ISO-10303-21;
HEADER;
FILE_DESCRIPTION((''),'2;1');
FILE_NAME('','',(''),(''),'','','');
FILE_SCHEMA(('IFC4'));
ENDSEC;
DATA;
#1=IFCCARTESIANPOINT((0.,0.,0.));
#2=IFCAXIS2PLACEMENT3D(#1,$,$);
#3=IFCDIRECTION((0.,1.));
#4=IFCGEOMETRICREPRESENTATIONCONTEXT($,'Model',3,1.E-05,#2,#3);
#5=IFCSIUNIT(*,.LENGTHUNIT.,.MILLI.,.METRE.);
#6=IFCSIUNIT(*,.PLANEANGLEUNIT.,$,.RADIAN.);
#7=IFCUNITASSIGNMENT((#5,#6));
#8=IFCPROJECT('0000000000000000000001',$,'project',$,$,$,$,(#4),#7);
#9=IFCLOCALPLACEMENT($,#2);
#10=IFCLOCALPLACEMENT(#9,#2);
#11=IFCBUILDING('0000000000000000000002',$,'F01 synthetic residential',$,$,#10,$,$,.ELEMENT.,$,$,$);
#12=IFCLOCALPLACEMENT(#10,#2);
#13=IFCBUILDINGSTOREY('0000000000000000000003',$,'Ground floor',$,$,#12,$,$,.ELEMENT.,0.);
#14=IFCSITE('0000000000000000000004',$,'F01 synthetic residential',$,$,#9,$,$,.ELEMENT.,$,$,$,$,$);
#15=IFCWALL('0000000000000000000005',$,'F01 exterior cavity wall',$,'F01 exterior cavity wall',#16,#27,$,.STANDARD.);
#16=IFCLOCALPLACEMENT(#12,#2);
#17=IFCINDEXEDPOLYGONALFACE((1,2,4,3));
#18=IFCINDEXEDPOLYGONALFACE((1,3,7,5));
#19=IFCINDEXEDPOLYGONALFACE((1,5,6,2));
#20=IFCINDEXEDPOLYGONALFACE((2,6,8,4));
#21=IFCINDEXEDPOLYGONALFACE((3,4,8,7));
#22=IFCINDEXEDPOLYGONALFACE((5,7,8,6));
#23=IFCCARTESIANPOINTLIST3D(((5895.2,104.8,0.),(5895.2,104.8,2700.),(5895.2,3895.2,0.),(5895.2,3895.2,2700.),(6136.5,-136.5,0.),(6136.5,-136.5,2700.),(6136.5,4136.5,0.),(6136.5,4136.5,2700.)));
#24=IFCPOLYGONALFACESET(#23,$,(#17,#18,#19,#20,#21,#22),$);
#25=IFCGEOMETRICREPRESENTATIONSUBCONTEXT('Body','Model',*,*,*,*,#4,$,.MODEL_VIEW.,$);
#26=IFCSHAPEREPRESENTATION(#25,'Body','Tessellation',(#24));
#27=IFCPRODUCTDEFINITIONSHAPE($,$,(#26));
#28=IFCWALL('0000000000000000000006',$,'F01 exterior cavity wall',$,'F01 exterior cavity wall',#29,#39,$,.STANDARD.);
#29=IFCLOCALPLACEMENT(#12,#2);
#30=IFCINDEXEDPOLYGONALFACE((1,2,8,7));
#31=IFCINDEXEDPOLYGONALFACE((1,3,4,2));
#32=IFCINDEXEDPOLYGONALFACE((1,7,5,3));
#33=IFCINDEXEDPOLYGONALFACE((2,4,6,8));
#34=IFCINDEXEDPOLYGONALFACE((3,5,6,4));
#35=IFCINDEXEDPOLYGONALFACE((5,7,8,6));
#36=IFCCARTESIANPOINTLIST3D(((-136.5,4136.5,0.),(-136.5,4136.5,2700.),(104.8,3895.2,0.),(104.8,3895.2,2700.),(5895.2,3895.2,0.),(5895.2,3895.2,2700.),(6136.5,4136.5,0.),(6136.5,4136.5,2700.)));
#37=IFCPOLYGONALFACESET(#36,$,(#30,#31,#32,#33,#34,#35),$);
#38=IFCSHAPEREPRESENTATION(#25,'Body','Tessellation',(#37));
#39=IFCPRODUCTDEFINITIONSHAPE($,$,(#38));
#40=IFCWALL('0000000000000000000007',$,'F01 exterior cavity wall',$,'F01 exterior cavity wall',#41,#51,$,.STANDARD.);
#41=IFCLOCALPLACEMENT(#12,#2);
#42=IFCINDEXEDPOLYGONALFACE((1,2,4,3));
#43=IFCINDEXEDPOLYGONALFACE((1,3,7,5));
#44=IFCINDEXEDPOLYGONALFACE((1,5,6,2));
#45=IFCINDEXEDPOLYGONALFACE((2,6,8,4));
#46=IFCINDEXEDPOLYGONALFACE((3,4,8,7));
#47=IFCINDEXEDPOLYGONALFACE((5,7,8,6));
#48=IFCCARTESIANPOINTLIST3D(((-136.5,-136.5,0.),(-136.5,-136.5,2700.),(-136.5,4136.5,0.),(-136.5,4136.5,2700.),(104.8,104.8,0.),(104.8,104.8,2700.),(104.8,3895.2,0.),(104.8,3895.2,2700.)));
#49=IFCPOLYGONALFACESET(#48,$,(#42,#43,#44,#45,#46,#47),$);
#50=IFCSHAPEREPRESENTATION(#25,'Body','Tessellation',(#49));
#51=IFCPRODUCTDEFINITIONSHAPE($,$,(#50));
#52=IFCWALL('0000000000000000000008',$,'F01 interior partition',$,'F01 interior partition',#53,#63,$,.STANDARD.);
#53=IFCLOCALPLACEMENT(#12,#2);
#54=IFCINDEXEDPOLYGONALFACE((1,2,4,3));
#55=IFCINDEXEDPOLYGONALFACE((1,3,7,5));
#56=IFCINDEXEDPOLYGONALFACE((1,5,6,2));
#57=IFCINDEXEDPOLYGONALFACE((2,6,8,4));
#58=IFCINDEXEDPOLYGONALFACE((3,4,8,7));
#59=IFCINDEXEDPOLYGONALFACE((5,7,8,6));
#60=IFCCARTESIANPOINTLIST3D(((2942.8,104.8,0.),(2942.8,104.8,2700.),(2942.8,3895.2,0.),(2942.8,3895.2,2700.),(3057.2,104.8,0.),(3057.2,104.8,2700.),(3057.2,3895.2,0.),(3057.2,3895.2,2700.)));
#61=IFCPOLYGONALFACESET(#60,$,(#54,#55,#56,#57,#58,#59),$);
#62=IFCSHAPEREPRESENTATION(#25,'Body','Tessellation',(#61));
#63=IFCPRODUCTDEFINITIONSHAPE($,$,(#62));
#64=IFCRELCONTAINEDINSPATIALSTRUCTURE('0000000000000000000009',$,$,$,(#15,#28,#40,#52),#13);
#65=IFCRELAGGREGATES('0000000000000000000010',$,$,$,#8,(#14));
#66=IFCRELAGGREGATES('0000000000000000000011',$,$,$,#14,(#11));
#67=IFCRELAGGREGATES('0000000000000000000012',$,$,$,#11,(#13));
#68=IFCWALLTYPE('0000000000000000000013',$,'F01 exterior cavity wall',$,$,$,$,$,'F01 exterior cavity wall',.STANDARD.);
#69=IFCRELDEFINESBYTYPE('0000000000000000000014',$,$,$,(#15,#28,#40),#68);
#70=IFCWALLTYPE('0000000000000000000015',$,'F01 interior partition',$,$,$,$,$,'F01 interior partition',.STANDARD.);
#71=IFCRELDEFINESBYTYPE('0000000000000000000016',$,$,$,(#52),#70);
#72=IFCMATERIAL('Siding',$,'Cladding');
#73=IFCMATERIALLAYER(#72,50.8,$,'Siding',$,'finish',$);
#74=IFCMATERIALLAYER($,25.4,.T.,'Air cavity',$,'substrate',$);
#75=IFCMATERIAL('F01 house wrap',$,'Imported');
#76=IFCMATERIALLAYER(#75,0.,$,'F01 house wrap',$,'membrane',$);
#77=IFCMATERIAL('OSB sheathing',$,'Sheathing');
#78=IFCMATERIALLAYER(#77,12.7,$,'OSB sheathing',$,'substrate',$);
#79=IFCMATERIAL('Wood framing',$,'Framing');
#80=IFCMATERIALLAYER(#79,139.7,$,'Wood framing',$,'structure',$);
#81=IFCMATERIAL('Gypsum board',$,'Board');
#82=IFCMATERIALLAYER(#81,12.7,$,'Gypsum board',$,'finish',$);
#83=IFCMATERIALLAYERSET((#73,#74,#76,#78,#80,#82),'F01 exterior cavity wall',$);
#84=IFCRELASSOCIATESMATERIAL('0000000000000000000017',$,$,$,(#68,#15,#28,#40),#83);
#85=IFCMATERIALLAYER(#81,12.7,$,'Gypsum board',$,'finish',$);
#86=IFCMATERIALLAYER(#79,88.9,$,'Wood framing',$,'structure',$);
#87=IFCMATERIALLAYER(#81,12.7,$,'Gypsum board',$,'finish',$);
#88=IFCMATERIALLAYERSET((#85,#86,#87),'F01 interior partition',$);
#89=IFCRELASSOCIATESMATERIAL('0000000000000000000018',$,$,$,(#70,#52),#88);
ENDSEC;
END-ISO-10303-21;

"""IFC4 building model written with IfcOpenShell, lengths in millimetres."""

from ifc_helpers import new_model, si_unit, direction, frame, origin, place, context, subcontext, project, spatial, polyline, outline, extrude, material, layer, layer_set, layer_usage, type_object, element, save


model = new_model("IFC4")

# Units and contexts
model_context = context("Model", 3, precision=1e-05, world=origin(), true_north=direction((0.0, 1.0)))
body_context = subcontext(model_context, "Body", "Model", "MODEL_VIEW")
ifc_project = project(units=[si_unit("LENGTHUNIT", "METRE", prefix="MILLI"), si_unit("PLANEANGLEUNIT", "RADIAN")], contexts=[model_context])

# Site, building, storey
site_placement = place(None, origin())
site = spatial("IfcSite", under=ifc_project, at=site_placement, Name="F01 synthetic residential", CompositionType="ELEMENT")
building_placement = place(site_placement, origin())
building = spatial("IfcBuilding", under=site, at=building_placement, Name="F01 synthetic residential", CompositionType="ELEMENT")
storey_placement = place(building_placement, origin())
storey = spatial("IfcBuildingStorey", under=building, at=storey_placement, Name="Ground floor", CompositionType="ELEMENT", Elevation=0.0)

# Shared definitions
ifc_material_1 = material(Name="Siding", Category="Cladding")
ifc_layer_1 = layer(ifc_material_1, 50.8, Name="Siding", Category="finish")
ifc_layer_2 = layer(None, 25.4, ventilated=True, Name="Air cavity", Category="substrate")
ifc_material_2 = material(Name="F01 house wrap", Category="Imported")
ifc_layer_3 = layer(ifc_material_2, 0.0, Name="F01 house wrap", Category="membrane")
ifc_material_3 = material(Name="OSB sheathing", Category="Sheathing")
ifc_layer_4 = layer(ifc_material_3, 12.7, Name="OSB sheathing", Category="substrate")
ifc_material_4 = material(Name="Wood framing", Category="Framing")
ifc_layer_5 = layer(ifc_material_4, 139.7, Name="Wood framing", Category="structure")
ifc_material_5 = material(Name="Gypsum board", Category="Board")
ifc_layer_6 = layer(ifc_material_5, 12.7, Name="Gypsum board", Category="finish")
ifc_layer_set_1 = layer_set([ifc_layer_1, ifc_layer_2, ifc_layer_3, ifc_layer_4, ifc_layer_5, ifc_layer_6], Name="F01 exterior cavity wall")
wall_type_1 = type_object("IfcWallType", Name="F01 exterior cavity wall", ElementType="F01 exterior cavity wall", PredefinedType="STANDARD", material=ifc_layer_set_1)

# Walls
ifc_layer_usage_1 = layer_usage(ifc_layer_set_1, "AXIS2", "POSITIVE", -120.7)
wall_1_placement = place(storey_placement, frame((6015.9, -15.9, 0.0), z_axis=(0.0, 0.0, 1.0), x_axis=(0.0, 1.0, 0.0)))
element("IfcWall", 1, at=wall_1_placement, inside=storey, type_object=wall_type_1, material=ifc_layer_usage_1, Name="F01 exterior cavity wall", ObjectType="F01 exterior cavity wall", PredefinedType="STANDARD", context=body_context, shape_type="SweptSolid", body=[
    extrude(outline(polyline([(-120.7, -120.7), (4152.4, -120.7), (3911.1, 120.7), (120.7, 120.7), (-120.7, -120.7)])), origin(), (0.0, 0.0, 1.0), 2700.0),
])
ifc_layer_usage_2 = layer_usage(ifc_layer_set_1, "AXIS2", "POSITIVE", -120.7)
wall_2_placement = place(storey_placement, frame((6015.9, 4015.9, 0.0), z_axis=(0.0, 0.0, 1.0), x_axis=(-1.0, 0.0, 0.0)))
element("IfcWall", 2, at=wall_2_placement, inside=storey, type_object=wall_type_1, material=ifc_layer_usage_2, Name="F01 exterior cavity wall", ObjectType="F01 exterior cavity wall", PredefinedType="STANDARD", context=body_context, shape_type="SweptSolid", body=[
    extrude(outline(polyline([(-120.7, -120.7), (6152.4, -120.7), (5911.1, 120.7), (120.7, 120.7), (-120.7, -120.7)])), origin(), (0.0, 0.0, 1.0), 2700.0),
])
ifc_layer_usage_3 = layer_usage(ifc_layer_set_1, "AXIS2", "POSITIVE", -120.7)
wall_3_placement = place(storey_placement, frame((-15.9, 4015.9, 0.0), z_axis=(0.0, 0.0, 1.0), x_axis=(0.0, -1.0, 0.0)))
element("IfcWall", 3, at=wall_3_placement, inside=storey, type_object=wall_type_1, material=ifc_layer_usage_3, Name="F01 exterior cavity wall", ObjectType="F01 exterior cavity wall", PredefinedType="STANDARD", context=body_context, shape_type="SweptSolid", body=[
    extrude(outline(polyline([(-120.7, -120.7), (4152.4, -120.7), (3911.1, 120.7), (120.7, 120.7), (-120.7, -120.7)])), origin(), (0.0, 0.0, 1.0), 2700.0),
])
ifc_layer_7 = layer(ifc_material_5, 12.7, Name="Gypsum board", Category="finish")
ifc_layer_8 = layer(ifc_material_4, 88.9, Name="Wood framing", Category="structure")
ifc_layer_9 = layer(ifc_material_5, 12.7, Name="Gypsum board", Category="finish")
ifc_layer_set_2 = layer_set([ifc_layer_7, ifc_layer_8, ifc_layer_9], Name="F01 interior partition")
ifc_layer_usage_4 = layer_usage(ifc_layer_set_2, "AXIS2", "NEGATIVE", 57.1)
wall_type_2 = type_object("IfcWallType", Name="F01 interior partition", ElementType="F01 interior partition", PredefinedType="STANDARD", material=ifc_layer_set_2)
wall_4_placement = place(storey_placement, frame((3000.0, 0.0, 0.0), z_axis=(0.0, 0.0, 1.0), x_axis=(0.0, 1.0, 0.0)))
element("IfcWall", 4, at=wall_4_placement, inside=storey, type_object=wall_type_2, material=ifc_layer_usage_4, Name="F01 interior partition", ObjectType="F01 interior partition", PredefinedType="STANDARD", context=body_context, shape_type="SweptSolid", body=[
    extrude(outline(polyline([(104.8, -57.1), (3895.2, -57.1), (3895.2, 57.1), (104.8, 57.1), (104.8, -57.1)])), origin(), (0.0, 0.0, 1.0), 2700.0),
])

save(model, "model.ifc")
